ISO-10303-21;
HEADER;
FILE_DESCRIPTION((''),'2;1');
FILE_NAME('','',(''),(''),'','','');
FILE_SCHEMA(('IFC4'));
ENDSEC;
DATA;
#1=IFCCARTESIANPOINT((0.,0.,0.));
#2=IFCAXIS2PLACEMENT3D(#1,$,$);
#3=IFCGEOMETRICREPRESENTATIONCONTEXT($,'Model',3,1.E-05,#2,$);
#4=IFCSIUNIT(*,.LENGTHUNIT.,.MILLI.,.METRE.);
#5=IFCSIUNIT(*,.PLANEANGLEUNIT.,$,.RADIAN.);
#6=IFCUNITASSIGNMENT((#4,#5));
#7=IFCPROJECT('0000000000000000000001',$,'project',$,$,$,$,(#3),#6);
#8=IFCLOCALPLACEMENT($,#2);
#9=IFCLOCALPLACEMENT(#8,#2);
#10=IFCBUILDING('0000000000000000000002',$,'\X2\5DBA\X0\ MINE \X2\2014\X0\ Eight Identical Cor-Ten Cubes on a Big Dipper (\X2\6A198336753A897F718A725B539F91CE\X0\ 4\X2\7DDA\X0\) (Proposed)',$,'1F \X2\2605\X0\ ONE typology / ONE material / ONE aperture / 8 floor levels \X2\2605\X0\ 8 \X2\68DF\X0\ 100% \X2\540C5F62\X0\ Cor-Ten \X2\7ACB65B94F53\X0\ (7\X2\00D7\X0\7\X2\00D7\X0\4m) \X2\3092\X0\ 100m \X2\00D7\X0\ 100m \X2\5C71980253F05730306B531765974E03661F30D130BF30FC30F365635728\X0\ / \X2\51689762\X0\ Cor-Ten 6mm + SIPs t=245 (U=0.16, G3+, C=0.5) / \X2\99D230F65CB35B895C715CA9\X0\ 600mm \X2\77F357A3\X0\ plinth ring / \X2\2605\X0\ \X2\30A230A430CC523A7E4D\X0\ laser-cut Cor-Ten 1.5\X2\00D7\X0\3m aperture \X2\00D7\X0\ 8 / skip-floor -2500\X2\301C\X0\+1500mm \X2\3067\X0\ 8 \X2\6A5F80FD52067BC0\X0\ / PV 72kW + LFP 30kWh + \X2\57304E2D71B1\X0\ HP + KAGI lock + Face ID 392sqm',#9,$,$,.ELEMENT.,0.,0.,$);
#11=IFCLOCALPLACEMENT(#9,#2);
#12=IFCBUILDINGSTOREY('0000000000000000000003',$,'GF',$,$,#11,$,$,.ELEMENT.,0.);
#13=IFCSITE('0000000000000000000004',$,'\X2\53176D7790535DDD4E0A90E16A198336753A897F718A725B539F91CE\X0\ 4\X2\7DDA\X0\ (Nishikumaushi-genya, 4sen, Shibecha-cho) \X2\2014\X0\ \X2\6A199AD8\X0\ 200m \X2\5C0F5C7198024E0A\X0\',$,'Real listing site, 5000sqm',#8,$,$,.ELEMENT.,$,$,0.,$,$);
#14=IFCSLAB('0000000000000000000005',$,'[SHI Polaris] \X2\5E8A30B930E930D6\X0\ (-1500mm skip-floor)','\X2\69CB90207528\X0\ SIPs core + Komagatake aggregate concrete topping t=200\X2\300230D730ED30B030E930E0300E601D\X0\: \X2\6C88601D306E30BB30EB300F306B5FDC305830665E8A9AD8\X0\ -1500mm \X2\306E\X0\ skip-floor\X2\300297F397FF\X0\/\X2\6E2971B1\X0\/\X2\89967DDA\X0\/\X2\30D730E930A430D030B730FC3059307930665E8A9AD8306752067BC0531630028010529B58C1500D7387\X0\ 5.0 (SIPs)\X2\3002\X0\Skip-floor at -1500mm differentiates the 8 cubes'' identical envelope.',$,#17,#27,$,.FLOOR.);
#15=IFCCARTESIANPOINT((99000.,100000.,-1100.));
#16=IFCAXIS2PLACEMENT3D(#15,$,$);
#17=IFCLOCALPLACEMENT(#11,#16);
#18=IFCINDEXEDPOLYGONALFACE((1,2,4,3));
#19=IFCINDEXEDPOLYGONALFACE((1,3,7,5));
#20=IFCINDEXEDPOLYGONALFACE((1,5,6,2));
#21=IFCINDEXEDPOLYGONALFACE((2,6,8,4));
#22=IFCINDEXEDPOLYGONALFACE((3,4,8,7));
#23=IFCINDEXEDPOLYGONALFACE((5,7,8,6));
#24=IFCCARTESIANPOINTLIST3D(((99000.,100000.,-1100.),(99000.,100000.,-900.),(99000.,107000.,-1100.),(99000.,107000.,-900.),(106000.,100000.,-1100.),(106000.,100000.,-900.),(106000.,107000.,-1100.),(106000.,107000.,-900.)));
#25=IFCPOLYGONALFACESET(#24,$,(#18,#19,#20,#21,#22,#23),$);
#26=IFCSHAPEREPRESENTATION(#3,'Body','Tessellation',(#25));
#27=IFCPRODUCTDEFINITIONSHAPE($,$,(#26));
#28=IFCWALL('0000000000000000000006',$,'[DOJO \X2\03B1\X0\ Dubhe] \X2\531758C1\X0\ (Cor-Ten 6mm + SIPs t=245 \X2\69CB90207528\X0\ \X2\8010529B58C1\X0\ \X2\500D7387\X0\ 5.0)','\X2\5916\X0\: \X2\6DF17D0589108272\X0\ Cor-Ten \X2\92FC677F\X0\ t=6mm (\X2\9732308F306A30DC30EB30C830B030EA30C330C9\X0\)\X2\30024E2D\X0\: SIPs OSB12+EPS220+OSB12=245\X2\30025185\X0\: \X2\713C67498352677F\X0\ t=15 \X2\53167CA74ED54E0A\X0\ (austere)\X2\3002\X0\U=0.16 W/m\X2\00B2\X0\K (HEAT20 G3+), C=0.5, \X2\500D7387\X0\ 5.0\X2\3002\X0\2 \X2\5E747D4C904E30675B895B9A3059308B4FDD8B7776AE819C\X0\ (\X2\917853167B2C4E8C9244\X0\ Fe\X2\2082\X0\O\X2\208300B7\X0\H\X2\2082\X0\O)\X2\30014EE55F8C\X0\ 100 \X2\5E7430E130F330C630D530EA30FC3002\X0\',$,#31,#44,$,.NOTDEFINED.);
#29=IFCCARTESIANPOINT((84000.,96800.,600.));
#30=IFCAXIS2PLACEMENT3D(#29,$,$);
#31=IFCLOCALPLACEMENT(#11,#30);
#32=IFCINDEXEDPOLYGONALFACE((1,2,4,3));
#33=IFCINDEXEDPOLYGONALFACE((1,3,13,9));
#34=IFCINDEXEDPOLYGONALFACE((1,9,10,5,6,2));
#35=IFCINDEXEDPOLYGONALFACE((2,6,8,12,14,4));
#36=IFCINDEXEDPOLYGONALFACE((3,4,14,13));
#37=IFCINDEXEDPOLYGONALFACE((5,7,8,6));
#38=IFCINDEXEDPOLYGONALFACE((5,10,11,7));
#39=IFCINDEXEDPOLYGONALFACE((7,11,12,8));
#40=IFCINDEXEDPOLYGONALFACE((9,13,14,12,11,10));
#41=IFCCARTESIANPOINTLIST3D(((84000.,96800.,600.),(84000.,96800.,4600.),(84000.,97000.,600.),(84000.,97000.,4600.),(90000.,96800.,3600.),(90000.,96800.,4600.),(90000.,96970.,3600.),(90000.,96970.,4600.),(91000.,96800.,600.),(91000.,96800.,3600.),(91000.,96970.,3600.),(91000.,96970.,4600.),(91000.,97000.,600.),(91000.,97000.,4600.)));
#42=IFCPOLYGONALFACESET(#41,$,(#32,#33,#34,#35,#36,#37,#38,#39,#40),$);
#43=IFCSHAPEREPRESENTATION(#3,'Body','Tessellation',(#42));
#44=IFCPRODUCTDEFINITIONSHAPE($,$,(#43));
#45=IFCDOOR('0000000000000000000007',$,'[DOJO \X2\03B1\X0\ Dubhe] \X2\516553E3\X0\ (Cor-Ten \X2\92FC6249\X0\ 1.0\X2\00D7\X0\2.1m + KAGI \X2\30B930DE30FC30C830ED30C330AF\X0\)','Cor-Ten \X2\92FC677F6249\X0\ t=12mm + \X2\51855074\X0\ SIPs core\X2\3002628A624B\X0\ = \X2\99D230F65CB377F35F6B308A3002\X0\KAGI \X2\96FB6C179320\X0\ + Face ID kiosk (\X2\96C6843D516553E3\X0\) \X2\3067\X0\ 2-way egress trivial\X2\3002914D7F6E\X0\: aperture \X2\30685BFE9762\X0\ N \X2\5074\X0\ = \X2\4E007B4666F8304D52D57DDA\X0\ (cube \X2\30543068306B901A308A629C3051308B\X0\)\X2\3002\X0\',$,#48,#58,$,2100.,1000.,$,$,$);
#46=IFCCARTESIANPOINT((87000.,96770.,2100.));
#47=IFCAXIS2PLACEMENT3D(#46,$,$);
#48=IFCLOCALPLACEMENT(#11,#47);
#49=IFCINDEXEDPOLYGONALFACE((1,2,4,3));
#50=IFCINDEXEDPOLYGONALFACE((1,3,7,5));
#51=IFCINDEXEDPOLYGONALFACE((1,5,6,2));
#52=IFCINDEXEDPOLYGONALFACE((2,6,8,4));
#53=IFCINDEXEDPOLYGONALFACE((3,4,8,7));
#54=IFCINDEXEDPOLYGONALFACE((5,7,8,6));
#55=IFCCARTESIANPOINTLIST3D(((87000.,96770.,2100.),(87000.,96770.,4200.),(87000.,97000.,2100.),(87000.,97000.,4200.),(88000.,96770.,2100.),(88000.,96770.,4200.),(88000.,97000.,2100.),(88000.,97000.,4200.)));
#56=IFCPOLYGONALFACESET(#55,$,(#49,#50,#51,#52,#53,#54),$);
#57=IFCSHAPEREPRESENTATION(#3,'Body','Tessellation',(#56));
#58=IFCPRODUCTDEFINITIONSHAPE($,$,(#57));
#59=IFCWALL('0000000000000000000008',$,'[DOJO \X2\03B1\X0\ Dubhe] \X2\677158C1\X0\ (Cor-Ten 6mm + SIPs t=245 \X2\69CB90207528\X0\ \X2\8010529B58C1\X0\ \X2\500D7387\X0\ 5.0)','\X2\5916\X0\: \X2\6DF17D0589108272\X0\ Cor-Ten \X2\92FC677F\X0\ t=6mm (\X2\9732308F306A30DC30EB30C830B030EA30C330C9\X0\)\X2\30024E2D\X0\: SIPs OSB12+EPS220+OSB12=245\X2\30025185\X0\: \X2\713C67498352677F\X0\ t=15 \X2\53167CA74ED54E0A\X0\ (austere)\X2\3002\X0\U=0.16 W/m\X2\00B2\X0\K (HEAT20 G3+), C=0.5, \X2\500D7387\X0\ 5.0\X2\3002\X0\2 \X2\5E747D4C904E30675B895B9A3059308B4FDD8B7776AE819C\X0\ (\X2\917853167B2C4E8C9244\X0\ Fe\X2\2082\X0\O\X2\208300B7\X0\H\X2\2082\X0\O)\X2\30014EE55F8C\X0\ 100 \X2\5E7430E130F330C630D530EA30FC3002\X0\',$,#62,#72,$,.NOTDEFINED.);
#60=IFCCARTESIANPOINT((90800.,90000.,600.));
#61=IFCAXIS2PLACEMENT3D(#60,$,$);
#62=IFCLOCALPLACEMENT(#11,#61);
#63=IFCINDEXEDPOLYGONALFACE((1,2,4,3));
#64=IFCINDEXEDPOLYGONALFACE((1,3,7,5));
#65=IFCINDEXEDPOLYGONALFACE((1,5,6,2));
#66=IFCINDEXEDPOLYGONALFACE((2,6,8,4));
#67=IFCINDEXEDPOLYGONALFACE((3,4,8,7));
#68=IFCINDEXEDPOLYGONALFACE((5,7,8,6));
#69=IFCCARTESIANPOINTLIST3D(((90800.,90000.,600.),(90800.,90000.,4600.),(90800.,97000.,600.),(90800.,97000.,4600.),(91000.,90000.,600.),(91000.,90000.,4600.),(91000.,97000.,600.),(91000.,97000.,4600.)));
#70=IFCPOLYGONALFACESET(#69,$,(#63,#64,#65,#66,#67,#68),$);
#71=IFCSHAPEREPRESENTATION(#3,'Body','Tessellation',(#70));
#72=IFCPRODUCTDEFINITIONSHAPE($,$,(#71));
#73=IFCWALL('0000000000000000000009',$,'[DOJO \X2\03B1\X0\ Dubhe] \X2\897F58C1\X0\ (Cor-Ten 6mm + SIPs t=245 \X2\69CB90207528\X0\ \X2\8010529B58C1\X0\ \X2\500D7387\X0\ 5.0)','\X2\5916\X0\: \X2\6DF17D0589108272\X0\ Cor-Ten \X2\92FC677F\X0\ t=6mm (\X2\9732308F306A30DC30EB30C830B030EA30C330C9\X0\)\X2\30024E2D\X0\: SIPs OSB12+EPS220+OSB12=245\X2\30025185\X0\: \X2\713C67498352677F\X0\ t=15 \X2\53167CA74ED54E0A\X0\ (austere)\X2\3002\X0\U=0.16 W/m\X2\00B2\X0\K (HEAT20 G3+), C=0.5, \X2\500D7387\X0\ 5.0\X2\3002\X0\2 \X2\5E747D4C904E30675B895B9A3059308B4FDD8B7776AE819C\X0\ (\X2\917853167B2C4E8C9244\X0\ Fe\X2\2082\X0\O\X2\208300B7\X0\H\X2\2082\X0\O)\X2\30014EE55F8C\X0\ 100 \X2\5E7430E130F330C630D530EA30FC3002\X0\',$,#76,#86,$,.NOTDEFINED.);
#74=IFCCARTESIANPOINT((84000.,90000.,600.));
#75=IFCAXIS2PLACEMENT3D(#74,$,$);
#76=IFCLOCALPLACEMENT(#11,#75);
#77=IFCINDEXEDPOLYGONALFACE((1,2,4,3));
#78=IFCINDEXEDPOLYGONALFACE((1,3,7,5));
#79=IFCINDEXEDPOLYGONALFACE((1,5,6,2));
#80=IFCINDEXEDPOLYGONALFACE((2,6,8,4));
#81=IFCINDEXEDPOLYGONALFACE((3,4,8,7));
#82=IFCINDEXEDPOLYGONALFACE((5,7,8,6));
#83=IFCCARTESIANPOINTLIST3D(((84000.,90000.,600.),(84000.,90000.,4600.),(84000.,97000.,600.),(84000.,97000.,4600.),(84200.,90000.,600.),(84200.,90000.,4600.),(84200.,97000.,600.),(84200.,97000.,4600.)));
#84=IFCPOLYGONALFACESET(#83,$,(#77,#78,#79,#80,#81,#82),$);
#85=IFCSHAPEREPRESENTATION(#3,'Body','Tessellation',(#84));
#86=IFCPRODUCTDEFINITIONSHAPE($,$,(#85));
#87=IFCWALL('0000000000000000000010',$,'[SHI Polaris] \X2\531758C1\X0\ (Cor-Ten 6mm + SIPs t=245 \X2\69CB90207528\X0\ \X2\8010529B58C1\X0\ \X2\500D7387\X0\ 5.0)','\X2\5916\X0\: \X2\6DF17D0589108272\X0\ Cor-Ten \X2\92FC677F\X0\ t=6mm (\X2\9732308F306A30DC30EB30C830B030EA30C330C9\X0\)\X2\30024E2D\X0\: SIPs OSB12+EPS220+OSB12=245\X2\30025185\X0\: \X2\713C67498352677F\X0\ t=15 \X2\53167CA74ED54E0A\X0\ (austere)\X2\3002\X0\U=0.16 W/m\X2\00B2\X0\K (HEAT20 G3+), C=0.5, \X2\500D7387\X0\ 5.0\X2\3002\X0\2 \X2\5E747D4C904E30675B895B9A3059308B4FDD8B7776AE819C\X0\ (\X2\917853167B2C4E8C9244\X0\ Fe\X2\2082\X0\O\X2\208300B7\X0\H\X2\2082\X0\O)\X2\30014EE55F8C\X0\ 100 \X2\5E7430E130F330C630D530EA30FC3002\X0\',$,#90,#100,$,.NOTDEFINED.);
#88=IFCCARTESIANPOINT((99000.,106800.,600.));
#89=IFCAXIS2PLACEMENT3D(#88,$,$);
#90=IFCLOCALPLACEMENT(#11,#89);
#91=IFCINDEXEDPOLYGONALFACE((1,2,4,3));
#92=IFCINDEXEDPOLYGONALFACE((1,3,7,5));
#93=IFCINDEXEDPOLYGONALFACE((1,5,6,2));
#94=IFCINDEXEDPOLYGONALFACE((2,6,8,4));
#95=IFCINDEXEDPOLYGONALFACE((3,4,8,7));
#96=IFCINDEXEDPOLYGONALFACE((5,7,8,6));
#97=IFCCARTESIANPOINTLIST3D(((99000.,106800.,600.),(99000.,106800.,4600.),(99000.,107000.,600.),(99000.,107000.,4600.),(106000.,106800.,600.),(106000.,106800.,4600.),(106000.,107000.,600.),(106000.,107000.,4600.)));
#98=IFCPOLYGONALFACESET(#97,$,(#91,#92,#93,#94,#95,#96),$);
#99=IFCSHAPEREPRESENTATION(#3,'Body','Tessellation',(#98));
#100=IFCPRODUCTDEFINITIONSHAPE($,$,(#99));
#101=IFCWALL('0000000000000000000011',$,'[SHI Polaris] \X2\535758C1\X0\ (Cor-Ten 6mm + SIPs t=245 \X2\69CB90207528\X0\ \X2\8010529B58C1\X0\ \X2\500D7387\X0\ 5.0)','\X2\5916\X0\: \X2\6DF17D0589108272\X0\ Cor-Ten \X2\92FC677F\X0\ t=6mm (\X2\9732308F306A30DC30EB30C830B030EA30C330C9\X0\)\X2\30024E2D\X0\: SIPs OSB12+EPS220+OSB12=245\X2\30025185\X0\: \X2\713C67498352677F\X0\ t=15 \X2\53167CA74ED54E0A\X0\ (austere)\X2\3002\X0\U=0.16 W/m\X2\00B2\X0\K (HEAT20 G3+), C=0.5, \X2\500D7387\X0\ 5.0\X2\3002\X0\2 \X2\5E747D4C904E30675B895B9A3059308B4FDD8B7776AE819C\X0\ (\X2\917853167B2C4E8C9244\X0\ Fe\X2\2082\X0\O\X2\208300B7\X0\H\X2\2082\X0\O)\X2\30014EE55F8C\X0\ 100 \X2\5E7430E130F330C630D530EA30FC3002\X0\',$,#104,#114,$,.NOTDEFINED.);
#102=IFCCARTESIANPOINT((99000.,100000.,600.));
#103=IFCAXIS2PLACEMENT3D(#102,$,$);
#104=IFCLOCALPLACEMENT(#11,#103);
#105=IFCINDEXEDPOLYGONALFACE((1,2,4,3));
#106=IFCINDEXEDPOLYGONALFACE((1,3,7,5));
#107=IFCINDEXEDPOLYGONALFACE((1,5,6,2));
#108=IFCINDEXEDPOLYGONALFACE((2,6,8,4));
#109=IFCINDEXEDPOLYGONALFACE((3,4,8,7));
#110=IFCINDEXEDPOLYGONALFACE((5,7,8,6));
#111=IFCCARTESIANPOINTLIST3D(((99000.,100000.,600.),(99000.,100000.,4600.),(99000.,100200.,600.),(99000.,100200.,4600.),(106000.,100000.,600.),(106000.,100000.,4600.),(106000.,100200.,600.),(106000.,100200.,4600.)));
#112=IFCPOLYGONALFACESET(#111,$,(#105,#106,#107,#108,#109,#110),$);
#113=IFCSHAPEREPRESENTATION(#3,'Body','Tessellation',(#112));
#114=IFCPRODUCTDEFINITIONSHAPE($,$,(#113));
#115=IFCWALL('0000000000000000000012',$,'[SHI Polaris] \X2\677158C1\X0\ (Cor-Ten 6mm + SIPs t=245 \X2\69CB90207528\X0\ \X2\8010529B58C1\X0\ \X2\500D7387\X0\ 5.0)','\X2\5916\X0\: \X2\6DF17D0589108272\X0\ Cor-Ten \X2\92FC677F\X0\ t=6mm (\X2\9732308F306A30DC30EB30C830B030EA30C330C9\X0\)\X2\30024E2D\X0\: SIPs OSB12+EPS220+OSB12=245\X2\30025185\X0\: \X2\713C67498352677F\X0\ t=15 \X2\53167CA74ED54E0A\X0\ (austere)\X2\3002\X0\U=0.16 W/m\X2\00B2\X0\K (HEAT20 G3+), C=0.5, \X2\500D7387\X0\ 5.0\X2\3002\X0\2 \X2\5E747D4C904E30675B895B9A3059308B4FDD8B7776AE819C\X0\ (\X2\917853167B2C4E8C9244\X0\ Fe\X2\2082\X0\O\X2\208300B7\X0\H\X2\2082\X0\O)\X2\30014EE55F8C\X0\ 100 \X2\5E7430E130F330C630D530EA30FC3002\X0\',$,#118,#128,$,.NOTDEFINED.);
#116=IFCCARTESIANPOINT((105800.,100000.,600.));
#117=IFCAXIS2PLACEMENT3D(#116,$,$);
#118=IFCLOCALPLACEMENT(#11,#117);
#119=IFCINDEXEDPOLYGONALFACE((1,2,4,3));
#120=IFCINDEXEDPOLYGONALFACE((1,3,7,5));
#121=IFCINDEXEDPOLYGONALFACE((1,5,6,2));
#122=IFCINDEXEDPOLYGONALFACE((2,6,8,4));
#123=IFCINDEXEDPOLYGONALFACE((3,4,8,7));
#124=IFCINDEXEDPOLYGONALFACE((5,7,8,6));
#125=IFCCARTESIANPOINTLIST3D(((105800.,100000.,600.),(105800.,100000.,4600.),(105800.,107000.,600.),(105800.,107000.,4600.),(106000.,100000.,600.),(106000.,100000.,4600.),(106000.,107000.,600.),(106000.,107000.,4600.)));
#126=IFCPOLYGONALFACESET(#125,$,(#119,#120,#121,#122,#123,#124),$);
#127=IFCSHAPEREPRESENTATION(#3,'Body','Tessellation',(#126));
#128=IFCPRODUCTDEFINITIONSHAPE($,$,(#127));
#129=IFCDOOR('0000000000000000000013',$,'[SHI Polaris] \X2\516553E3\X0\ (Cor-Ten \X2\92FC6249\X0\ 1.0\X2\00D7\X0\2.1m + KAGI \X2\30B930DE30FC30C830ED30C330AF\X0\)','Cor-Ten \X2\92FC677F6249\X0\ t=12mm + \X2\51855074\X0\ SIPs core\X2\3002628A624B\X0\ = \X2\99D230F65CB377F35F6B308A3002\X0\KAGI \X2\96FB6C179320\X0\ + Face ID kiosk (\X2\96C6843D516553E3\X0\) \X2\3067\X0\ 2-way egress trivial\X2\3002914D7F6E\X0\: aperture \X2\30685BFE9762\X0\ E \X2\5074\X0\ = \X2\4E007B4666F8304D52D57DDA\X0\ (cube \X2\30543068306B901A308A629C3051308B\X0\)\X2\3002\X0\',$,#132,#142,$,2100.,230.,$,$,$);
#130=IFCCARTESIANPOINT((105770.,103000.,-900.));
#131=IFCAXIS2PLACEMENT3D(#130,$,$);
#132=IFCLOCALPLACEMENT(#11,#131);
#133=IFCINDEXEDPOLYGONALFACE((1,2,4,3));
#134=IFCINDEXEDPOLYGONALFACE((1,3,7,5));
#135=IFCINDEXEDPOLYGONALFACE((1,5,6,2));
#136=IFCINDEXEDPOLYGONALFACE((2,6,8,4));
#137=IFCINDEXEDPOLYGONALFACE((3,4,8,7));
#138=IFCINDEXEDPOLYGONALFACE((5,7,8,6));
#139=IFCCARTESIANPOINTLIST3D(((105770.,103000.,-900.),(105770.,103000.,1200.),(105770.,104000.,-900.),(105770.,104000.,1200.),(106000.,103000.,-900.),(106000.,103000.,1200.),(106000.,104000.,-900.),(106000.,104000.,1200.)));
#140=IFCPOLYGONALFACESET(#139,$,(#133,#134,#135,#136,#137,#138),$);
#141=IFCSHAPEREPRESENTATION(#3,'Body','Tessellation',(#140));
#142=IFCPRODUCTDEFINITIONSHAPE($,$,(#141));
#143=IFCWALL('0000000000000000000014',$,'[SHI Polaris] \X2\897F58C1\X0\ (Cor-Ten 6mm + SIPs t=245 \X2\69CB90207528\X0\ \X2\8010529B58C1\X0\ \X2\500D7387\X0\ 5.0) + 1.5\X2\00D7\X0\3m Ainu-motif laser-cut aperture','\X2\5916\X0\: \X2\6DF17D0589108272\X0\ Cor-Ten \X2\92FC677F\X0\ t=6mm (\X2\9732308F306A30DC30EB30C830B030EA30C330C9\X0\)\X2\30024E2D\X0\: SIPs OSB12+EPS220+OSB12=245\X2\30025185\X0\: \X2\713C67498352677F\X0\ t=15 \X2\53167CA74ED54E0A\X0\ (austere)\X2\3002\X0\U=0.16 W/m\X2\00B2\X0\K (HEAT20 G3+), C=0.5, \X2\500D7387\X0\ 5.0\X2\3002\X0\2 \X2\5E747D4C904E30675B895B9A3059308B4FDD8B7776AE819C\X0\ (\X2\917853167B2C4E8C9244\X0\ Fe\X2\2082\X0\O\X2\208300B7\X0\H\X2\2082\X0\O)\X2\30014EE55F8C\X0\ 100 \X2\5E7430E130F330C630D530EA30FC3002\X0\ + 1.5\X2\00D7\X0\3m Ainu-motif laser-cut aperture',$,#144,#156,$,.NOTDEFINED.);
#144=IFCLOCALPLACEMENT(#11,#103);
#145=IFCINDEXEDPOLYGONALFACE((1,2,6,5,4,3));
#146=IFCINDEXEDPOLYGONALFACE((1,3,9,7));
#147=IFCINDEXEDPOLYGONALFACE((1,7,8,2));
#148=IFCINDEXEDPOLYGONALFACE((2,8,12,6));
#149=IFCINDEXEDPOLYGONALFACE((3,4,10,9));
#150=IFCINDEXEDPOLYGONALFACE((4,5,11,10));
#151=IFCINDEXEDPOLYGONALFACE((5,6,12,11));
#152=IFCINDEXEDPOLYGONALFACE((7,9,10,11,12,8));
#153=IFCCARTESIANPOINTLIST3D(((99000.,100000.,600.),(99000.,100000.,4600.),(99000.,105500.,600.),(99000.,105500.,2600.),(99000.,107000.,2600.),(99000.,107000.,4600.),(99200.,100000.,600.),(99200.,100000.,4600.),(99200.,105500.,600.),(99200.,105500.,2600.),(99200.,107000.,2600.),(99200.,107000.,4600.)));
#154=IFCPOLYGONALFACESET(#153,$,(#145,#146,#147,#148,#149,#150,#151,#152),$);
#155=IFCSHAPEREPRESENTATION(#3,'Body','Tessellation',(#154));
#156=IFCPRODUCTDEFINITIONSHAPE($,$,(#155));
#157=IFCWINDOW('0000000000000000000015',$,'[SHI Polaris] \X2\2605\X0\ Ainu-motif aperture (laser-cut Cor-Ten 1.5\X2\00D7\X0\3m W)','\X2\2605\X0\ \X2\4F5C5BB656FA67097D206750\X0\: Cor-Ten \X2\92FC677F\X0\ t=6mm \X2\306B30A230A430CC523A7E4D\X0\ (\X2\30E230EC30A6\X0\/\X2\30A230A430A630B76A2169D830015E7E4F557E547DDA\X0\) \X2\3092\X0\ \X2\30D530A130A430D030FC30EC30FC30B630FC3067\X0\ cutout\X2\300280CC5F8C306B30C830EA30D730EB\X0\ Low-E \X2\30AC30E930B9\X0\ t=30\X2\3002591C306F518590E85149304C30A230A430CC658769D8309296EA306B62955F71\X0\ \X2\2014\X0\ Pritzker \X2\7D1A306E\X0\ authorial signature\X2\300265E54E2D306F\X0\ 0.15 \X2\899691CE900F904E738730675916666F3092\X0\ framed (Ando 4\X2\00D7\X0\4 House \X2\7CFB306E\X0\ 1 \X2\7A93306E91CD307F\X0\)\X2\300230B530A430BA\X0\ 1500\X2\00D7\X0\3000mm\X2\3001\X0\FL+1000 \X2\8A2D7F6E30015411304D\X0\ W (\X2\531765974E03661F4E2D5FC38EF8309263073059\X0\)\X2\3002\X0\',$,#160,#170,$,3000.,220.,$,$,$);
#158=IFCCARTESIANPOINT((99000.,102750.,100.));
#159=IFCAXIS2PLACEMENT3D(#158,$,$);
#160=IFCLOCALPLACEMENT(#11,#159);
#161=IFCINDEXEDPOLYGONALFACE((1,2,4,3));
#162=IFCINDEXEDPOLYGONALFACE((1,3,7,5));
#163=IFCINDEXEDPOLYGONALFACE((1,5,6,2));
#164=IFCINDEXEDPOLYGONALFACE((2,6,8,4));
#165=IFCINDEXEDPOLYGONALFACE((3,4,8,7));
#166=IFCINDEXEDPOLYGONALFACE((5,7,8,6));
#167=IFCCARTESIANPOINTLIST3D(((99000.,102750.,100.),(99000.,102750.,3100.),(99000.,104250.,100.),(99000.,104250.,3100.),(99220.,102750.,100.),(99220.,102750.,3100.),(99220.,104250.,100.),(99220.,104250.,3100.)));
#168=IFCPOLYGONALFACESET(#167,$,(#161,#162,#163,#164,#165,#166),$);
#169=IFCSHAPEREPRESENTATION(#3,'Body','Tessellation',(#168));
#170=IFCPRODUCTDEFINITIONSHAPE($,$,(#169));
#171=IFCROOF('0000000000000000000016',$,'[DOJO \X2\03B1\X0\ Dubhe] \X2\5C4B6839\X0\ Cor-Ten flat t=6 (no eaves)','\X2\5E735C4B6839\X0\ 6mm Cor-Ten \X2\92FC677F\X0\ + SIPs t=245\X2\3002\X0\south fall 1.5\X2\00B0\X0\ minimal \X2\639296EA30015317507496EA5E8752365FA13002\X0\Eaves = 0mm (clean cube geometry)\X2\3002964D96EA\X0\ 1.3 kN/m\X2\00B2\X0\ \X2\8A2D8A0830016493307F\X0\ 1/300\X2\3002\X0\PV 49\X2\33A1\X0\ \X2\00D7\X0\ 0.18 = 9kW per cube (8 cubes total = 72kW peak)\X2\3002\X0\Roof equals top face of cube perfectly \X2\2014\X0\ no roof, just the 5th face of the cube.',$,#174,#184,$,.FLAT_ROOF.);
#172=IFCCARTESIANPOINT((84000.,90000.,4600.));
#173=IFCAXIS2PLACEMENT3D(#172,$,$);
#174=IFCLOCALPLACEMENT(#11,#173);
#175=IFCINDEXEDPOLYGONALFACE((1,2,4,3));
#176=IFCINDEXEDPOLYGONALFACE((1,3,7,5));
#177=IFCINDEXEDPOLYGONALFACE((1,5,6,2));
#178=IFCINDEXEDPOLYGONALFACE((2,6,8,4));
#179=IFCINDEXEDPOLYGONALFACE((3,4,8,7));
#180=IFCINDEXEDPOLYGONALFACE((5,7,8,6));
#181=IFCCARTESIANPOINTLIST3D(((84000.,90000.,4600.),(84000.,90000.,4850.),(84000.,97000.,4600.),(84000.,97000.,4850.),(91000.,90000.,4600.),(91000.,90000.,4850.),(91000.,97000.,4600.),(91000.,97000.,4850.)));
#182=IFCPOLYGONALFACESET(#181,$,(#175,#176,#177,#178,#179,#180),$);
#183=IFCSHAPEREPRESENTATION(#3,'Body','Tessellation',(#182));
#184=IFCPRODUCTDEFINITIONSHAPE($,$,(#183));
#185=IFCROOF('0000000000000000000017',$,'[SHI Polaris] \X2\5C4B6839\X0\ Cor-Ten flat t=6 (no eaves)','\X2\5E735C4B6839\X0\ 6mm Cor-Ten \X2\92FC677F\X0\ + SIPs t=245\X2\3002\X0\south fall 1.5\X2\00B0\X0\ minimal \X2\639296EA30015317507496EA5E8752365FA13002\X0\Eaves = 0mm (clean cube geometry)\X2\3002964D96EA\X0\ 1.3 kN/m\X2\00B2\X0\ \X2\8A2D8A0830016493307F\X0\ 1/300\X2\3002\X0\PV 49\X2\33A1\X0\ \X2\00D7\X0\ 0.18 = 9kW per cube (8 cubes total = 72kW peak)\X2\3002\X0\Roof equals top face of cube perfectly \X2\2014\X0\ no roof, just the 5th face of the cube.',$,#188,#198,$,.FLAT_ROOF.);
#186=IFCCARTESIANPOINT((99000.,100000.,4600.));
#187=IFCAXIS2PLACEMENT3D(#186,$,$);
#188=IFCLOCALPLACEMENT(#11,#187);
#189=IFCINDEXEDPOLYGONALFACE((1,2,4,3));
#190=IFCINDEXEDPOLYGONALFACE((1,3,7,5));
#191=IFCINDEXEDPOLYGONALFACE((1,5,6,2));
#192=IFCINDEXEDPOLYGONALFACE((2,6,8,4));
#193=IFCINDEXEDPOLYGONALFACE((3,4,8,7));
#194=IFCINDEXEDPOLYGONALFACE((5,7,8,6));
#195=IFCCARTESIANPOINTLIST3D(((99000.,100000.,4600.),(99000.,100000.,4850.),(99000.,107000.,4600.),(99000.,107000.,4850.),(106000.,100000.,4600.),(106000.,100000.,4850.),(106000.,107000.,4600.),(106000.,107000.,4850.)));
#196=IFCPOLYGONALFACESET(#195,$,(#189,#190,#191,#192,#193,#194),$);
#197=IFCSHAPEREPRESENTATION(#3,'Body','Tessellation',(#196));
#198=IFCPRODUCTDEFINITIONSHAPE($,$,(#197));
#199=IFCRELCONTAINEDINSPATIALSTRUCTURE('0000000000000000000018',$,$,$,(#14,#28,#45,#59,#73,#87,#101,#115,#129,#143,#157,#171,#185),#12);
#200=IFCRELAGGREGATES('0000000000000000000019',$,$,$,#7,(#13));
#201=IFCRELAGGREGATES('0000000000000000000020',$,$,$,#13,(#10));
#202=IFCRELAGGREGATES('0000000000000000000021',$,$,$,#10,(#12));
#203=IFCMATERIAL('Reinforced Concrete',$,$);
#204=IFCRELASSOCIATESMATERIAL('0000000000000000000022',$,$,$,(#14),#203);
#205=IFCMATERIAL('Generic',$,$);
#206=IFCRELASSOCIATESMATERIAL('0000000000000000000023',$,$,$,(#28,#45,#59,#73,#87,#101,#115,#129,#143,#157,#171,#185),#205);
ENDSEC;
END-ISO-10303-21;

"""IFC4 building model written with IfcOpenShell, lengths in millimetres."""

from ifc_helpers import new_model, si_unit, frame, frame_2d, origin, place, context, project, spatial, rectangle, extrude, material, element, fill, save


model = new_model("IFC4")

# Units and contexts
model_context = context("Model", 3, precision=1e-05, world=origin())
ifc_project = project(units=[si_unit("LENGTHUNIT", "METRE", prefix="MILLI"), si_unit("PLANEANGLEUNIT", "RADIAN")], contexts=[model_context])

# Site, building, storey
site_placement = place(None, origin())
site = spatial("IfcSite", under=ifc_project, at=site_placement, Name="北海道川上郡標茶町西熊牛原野 4線 (Nishikumaushi-genya, 4sen, Shibecha-cho) — 標高 200m 小山頂上", ObjectType="Real listing site, 5000sqm", CompositionType="ELEMENT", RefElevation=0.0)
building_placement = place(site_placement, origin())
building = spatial("IfcBuilding", under=site, at=building_placement, Name="嶺 MINE — Eight Identical Cor-Ten Cubes on a Big Dipper (標茶町西熊牛原野 4線) (Proposed)", ObjectType="1F ★ ONE typology / ONE material / ONE aperture / 8 floor levels ★ 8 棟 100% 同形 Cor-Ten 立方体 (7×7×4m) を 100m × 100m 山頂台地に北斗七星パターン散在 / 全面 Cor-Ten 6mm + SIPs t=245 (U=0.16, G3+, C=0.5) / 駒ヶ岳安山岩 600mm 石垣 plinth ring / ★ アイヌ刺繍 laser-cut Cor-Ten 1.5×3m aperture × 8 / skip-floor -2500〜+1500mm で 8 機能分節 / PV 72kW + LFP 30kWh + 地中熱 HP + KAGI lock + Face ID 392sqm", CompositionType="ELEMENT", ElevationOfRefHeight=0.0, ElevationOfTerrain=0.0)
storey_placement = place(building_placement, origin())
storey = spatial("IfcBuildingStorey", under=building, at=storey_placement, Name="GF", CompositionType="ELEMENT", Elevation=0.0)

# Slab
ifc_material_1 = material(Name="Reinforced Concrete")
slab_placement = place(storey_placement, frame((99000.0, 100000.0, -1100.0)))
element("IfcSlab", 1, at=slab_placement, inside=storey, material=ifc_material_1, Name="[SHI Polaris] 床スラブ (-1500mm skip-floor)", Description="構造用 SIPs core + Komagatake aggregate concrete topping t=200。プログラム『思: 沈思のセル』に応じて床高 -1500mm の skip-floor。音響/温熱/視線/プライバシーすべて床高で分節化。耐力壁倍率 5.0 (SIPs)。Skip-floor at -1500mm differentiates the 8 cubes' identical envelope.", PredefinedType="FLOOR", context=model_context, shape_type="SweptSolid", body=[
    extrude(rectangle(XDim=7000.0, YDim=7000.0, at=frame_2d((3500.0, 3500.0))), frame((99000.0, 100000.0, -1100.0)), (0.0, 0.0, 1.0), 200.0),
])

# Wall, opening, door
ifc_material_2 = material(Name="Generic")
wall_1_placement = place(storey_placement, frame((84000.0, 96800.0, 600.0)))
wall_1 = element("IfcWall", 2, at=wall_1_placement, inside=storey, material=ifc_material_2, Name="[DOJO α Dubhe] 北壁 (Cor-Ten 6mm + SIPs t=245 構造用 耐力壁 倍率 5.0)", Description="外: 深紅褐色 Cor-Ten 鋼板 t=6mm (露わなボルトグリッド)。中: SIPs OSB12+EPS220+OSB12=245。内: 焼杉荒板 t=15 化粧仕上 (austere)。U=0.16 W/m²K (HEAT20 G3+), C=0.5, 倍率 5.0。2 年経過で安定する保護皮膜 (酸化第二鉄 Fe₂O₃·H₂O)、以後 100 年メンテフリー。", PredefinedType="NOTDEFINED", context=model_context, shape_type="SweptSolid", body=[
    extrude(rectangle(XDim=7000.0, YDim=200.0, at=frame_2d((3500.0, 100.0))), frame((84000.0, 96800.0, 600.0)), (0.0, 0.0, 1.0), 4000.0),
])
opening_1_placement = place(storey_placement, frame((87000.0, 96770.0, 2100.0)))
opening_1 = element("IfcOpeningElement", 3, at=opening_1_placement, cuts=wall_1, PredefinedType="NOTDEFINED", context=model_context, shape_type="SweptSolid", body=[
    extrude(rectangle(XDim=1000.0, YDim=230.0, at=frame_2d((500.0, 115.0))), frame((87000.0, 96770.0, 2100.0)), (0.0, 0.0, 1.0), 2100.0),
])
door_1_placement = place(storey_placement, frame((87000.0, 96770.0, 2100.0)))
door_1 = element("IfcDoor", 4, at=door_1_placement, inside=storey, material=ifc_material_2, Name="[DOJO α Dubhe] 入口 (Cor-Ten 鋼扉 1.0×2.1m + KAGI スマートロック)", Description="Cor-Ten 鋼板扉 t=12mm + 内側 SIPs core。把手 = 駒ヶ岳石彫り。KAGI 電気錠 + Face ID kiosk (集落入口) で 2-way egress trivial。配置: aperture と対面 N 側 = 一筆書き動線 (cube ごとに通り抜ける)。", OverallHeight=2100.0, OverallWidth=1000.0, context=model_context, shape_type="SweptSolid", body=[
    extrude(rectangle(XDim=1000.0, YDim=230.0, at=frame_2d((500.0, 115.0))), frame((87000.0, 96770.0, 2100.0)), (0.0, 0.0, 1.0), 2100.0),
])
fill(opening_1, door_1)

# Walls
wall_2_placement = place(storey_placement, frame((90800.0, 90000.0, 600.0)))
element("IfcWall", 5, at=wall_2_placement, inside=storey, material=ifc_material_2, Name="[DOJO α Dubhe] 東壁 (Cor-Ten 6mm + SIPs t=245 構造用 耐力壁 倍率 5.0)", Description="外: 深紅褐色 Cor-Ten 鋼板 t=6mm (露わなボルトグリッド)。中: SIPs OSB12+EPS220+OSB12=245。内: 焼杉荒板 t=15 化粧仕上 (austere)。U=0.16 W/m²K (HEAT20 G3+), C=0.5, 倍率 5.0。2 年経過で安定する保護皮膜 (酸化第二鉄 Fe₂O₃·H₂O)、以後 100 年メンテフリー。", PredefinedType="NOTDEFINED", context=model_context, shape_type="SweptSolid", body=[
    extrude(rectangle(XDim=200.0, YDim=7000.0, at=frame_2d((100.0, 3500.0))), frame((90800.0, 90000.0, 600.0)), (0.0, 0.0, 1.0), 4000.0),
])
wall_3_placement = place(storey_placement, frame((84000.0, 90000.0, 600.0)))
element("IfcWall", 6, at=wall_3_placement, inside=storey, material=ifc_material_2, Name="[DOJO α Dubhe] 西壁 (Cor-Ten 6mm + SIPs t=245 構造用 耐力壁 倍率 5.0)", Description="外: 深紅褐色 Cor-Ten 鋼板 t=6mm (露わなボルトグリッド)。中: SIPs OSB12+EPS220+OSB12=245。内: 焼杉荒板 t=15 化粧仕上 (austere)。U=0.16 W/m²K (HEAT20 G3+), C=0.5, 倍率 5.0。2 年経過で安定する保護皮膜 (酸化第二鉄 Fe₂O₃·H₂O)、以後 100 年メンテフリー。", PredefinedType="NOTDEFINED", context=model_context, shape_type="SweptSolid", body=[
    extrude(rectangle(XDim=200.0, YDim=7000.0, at=frame_2d((100.0, 3500.0))), frame((84000.0, 90000.0, 600.0)), (0.0, 0.0, 1.0), 4000.0),
])
wall_4_placement = place(storey_placement, frame((99000.0, 106800.0, 600.0)))
element("IfcWall", 7, at=wall_4_placement, inside=storey, material=ifc_material_2, Name="[SHI Polaris] 北壁 (Cor-Ten 6mm + SIPs t=245 構造用 耐力壁 倍率 5.0)", Description="外: 深紅褐色 Cor-Ten 鋼板 t=6mm (露わなボルトグリッド)。中: SIPs OSB12+EPS220+OSB12=245。内: 焼杉荒板 t=15 化粧仕上 (austere)。U=0.16 W/m²K (HEAT20 G3+), C=0.5, 倍率 5.0。2 年経過で安定する保護皮膜 (酸化第二鉄 Fe₂O₃·H₂O)、以後 100 年メンテフリー。", PredefinedType="NOTDEFINED", context=model_context, shape_type="SweptSolid", body=[
    extrude(rectangle(XDim=7000.0, YDim=200.0, at=frame_2d((3500.0, 100.0))), frame((99000.0, 106800.0, 600.0)), (0.0, 0.0, 1.0), 4000.0),
])
wall_5_placement = place(storey_placement, frame((99000.0, 100000.0, 600.0)))
element("IfcWall", 8, at=wall_5_placement, inside=storey, material=ifc_material_2, Name="[SHI Polaris] 南壁 (Cor-Ten 6mm + SIPs t=245 構造用 耐力壁 倍率 5.0)", Description="外: 深紅褐色 Cor-Ten 鋼板 t=6mm (露わなボルトグリッド)。中: SIPs OSB12+EPS220+OSB12=245。内: 焼杉荒板 t=15 化粧仕上 (austere)。U=0.16 W/m²K (HEAT20 G3+), C=0.5, 倍率 5.0。2 年経過で安定する保護皮膜 (酸化第二鉄 Fe₂O₃·H₂O)、以後 100 年メンテフリー。", PredefinedType="NOTDEFINED", context=model_context, shape_type="SweptSolid", body=[
    extrude(rectangle(XDim=7000.0, YDim=200.0, at=frame_2d((3500.0, 100.0))), frame((99000.0, 100000.0, 600.0)), (0.0, 0.0, 1.0), 4000.0),
])

# Wall, opening, door
wall_6_placement = place(storey_placement, frame((105800.0, 100000.0, 600.0)))
wall_6 = element("IfcWall", 9, at=wall_6_placement, inside=storey, material=ifc_material_2, Name="[SHI Polaris] 東壁 (Cor-Ten 6mm + SIPs t=245 構造用 耐力壁 倍率 5.0)", Description="外: 深紅褐色 Cor-Ten 鋼板 t=6mm (露わなボルトグリッド)。中: SIPs OSB12+EPS220+OSB12=245。内: 焼杉荒板 t=15 化粧仕上 (austere)。U=0.16 W/m²K (HEAT20 G3+), C=0.5, 倍率 5.0。2 年経過で安定する保護皮膜 (酸化第二鉄 Fe₂O₃·H₂O)、以後 100 年メンテフリー。", PredefinedType="NOTDEFINED", context=model_context, shape_type="SweptSolid", body=[
    extrude(rectangle(XDim=200.0, YDim=7000.0, at=frame_2d((100.0, 3500.0))), frame((105800.0, 100000.0, 600.0)), (0.0, 0.0, 1.0), 4000.0),
])
opening_2_placement = place(storey_placement, frame((105770.0, 103000.0, -900.0)))
opening_2 = element("IfcOpeningElement", 10, at=opening_2_placement, cuts=wall_6, PredefinedType="NOTDEFINED", context=model_context, shape_type="SweptSolid", body=[
    extrude(rectangle(XDim=230.0, YDim=1000.0, at=frame_2d((115.0, 500.0))), frame((105770.0, 103000.0, -900.0)), (0.0, 0.0, 1.0), 2100.0),
])
door_2_placement = place(storey_placement, frame((105770.0, 103000.0, -900.0)))
door_2 = element("IfcDoor", 11, at=door_2_placement, inside=storey, material=ifc_material_2, Name="[SHI Polaris] 入口 (Cor-Ten 鋼扉 1.0×2.1m + KAGI スマートロック)", Description="Cor-Ten 鋼板扉 t=12mm + 内側 SIPs core。把手 = 駒ヶ岳石彫り。KAGI 電気錠 + Face ID kiosk (集落入口) で 2-way egress trivial。配置: aperture と対面 E 側 = 一筆書き動線 (cube ごとに通り抜ける)。", OverallHeight=2100.0, OverallWidth=230.0, context=model_context, shape_type="SweptSolid", body=[
    extrude(rectangle(XDim=230.0, YDim=1000.0, at=frame_2d((115.0, 500.0))), frame((105770.0, 103000.0, -900.0)), (0.0, 0.0, 1.0), 2100.0),
])
fill(opening_2, door_2)

# Wall, opening, window
wall_7_placement = place(storey_placement, frame((99000.0, 100000.0, 600.0)))
wall_7 = element("IfcWall", 12, at=wall_7_placement, inside=storey, material=ifc_material_2, Name="[SHI Polaris] 西壁 (Cor-Ten 6mm + SIPs t=245 構造用 耐力壁 倍率 5.0) + 1.5×3m Ainu-motif laser-cut aperture", Description="外: 深紅褐色 Cor-Ten 鋼板 t=6mm (露わなボルトグリッド)。中: SIPs OSB12+EPS220+OSB12=245。内: 焼杉荒板 t=15 化粧仕上 (austere)。U=0.16 W/m²K (HEAT20 G3+), C=0.5, 倍率 5.0。2 年経過で安定する保護皮膜 (酸化第二鉄 Fe₂O₃·H₂O)、以後 100 年メンテフリー。 + 1.5×3m Ainu-motif laser-cut aperture", PredefinedType="NOTDEFINED", context=model_context, shape_type="SweptSolid", body=[
    extrude(rectangle(XDim=200.0, YDim=7000.0, at=frame_2d((100.0, 3500.0))), frame((99000.0, 100000.0, 600.0)), (0.0, 0.0, 1.0), 4000.0),
])
opening_3_placement = place(storey_placement, frame((99000.0, 102750.0, 100.0)))
opening_3 = element("IfcOpeningElement", 13, at=opening_3_placement, cuts=wall_7, PredefinedType="NOTDEFINED", context=model_context, shape_type="SweptSolid", body=[
    extrude(rectangle(XDim=220.0, YDim=1500.0, at=frame_2d((110.0, 750.0))), frame((99000.0, 102750.0, 100.0)), (0.0, 0.0, 1.0), 3000.0),
])
window_placement = place(storey_placement, frame((99000.0, 102750.0, 100.0)))
window = element("IfcWindow", 14, at=window_placement, inside=storey, material=ifc_material_2, Name="[SHI Polaris] ★ Ainu-motif aperture (laser-cut Cor-Ten 1.5×3m W)", Description="★ 作家固有素材: Cor-Ten 鋼板 t=6mm にアイヌ刺繍 (モレウ/アイウシ模様、幾何織線) を ファイバーレーザーで cutout。背後にトリプル Low-E ガラス t=30。夜は内部光がアイヌ文様を雪に投影 — Pritzker 級の authorial signature。日中は 0.15 視野透過率で外景を framed (Ando 4×4 House 系の 1 窓の重み)。サイズ 1500×3000mm、FL+1000 設置、向き W (北斗七星中心軸を指す)。", OverallHeight=3000.0, OverallWidth=220.0, context=model_context, shape_type="SweptSolid", body=[
    extrude(rectangle(XDim=220.0, YDim=1500.0, at=frame_2d((110.0, 750.0))), frame((99000.0, 102750.0, 100.0)), (0.0, 0.0, 1.0), 3000.0),
])
fill(opening_3, window)

# Roofs
roof_1_placement = place(storey_placement, frame((84000.0, 90000.0, 4600.0)))
element("IfcRoof", 15, at=roof_1_placement, inside=storey, material=ifc_material_2, Name="[DOJO α Dubhe] 屋根 Cor-Ten flat t=6 (no eaves)", Description="平屋根 6mm Cor-Ten 鋼板 + SIPs t=245。south fall 1.5° minimal 排雪、北側雪庇制御。Eaves = 0mm (clean cube geometry)。降雪 1.3 kN/m² 設計、撓み 1/300。PV 49㎡ × 0.18 = 9kW per cube (8 cubes total = 72kW peak)。Roof equals top face of cube perfectly — no roof, just the 5th face of the cube.", PredefinedType="FLAT_ROOF", context=model_context, shape_type="SweptSolid", body=[
    extrude(rectangle(XDim=7000.0, YDim=7000.0, at=frame_2d((3500.0, 3500.0))), frame((84000.0, 90000.0, 4600.0)), (0.0, 0.0, 1.0), 250.0),
])
roof_2_placement = place(storey_placement, frame((99000.0, 100000.0, 4600.0)))
element("IfcRoof", 16, at=roof_2_placement, inside=storey, material=ifc_material_2, Name="[SHI Polaris] 屋根 Cor-Ten flat t=6 (no eaves)", Description="平屋根 6mm Cor-Ten 鋼板 + SIPs t=245。south fall 1.5° minimal 排雪、北側雪庇制御。Eaves = 0mm (clean cube geometry)。降雪 1.3 kN/m² 設計、撓み 1/300。PV 49㎡ × 0.18 = 9kW per cube (8 cubes total = 72kW peak)。Roof equals top face of cube perfectly — no roof, just the 5th face of the cube.", PredefinedType="FLAT_ROOF", context=model_context, shape_type="SweptSolid", body=[
    extrude(rectangle(XDim=7000.0, YDim=7000.0, at=frame_2d((3500.0, 3500.0))), frame((99000.0, 100000.0, 4600.0)), (0.0, 0.0, 1.0), 250.0),
])

save(model, "model.ifc")
